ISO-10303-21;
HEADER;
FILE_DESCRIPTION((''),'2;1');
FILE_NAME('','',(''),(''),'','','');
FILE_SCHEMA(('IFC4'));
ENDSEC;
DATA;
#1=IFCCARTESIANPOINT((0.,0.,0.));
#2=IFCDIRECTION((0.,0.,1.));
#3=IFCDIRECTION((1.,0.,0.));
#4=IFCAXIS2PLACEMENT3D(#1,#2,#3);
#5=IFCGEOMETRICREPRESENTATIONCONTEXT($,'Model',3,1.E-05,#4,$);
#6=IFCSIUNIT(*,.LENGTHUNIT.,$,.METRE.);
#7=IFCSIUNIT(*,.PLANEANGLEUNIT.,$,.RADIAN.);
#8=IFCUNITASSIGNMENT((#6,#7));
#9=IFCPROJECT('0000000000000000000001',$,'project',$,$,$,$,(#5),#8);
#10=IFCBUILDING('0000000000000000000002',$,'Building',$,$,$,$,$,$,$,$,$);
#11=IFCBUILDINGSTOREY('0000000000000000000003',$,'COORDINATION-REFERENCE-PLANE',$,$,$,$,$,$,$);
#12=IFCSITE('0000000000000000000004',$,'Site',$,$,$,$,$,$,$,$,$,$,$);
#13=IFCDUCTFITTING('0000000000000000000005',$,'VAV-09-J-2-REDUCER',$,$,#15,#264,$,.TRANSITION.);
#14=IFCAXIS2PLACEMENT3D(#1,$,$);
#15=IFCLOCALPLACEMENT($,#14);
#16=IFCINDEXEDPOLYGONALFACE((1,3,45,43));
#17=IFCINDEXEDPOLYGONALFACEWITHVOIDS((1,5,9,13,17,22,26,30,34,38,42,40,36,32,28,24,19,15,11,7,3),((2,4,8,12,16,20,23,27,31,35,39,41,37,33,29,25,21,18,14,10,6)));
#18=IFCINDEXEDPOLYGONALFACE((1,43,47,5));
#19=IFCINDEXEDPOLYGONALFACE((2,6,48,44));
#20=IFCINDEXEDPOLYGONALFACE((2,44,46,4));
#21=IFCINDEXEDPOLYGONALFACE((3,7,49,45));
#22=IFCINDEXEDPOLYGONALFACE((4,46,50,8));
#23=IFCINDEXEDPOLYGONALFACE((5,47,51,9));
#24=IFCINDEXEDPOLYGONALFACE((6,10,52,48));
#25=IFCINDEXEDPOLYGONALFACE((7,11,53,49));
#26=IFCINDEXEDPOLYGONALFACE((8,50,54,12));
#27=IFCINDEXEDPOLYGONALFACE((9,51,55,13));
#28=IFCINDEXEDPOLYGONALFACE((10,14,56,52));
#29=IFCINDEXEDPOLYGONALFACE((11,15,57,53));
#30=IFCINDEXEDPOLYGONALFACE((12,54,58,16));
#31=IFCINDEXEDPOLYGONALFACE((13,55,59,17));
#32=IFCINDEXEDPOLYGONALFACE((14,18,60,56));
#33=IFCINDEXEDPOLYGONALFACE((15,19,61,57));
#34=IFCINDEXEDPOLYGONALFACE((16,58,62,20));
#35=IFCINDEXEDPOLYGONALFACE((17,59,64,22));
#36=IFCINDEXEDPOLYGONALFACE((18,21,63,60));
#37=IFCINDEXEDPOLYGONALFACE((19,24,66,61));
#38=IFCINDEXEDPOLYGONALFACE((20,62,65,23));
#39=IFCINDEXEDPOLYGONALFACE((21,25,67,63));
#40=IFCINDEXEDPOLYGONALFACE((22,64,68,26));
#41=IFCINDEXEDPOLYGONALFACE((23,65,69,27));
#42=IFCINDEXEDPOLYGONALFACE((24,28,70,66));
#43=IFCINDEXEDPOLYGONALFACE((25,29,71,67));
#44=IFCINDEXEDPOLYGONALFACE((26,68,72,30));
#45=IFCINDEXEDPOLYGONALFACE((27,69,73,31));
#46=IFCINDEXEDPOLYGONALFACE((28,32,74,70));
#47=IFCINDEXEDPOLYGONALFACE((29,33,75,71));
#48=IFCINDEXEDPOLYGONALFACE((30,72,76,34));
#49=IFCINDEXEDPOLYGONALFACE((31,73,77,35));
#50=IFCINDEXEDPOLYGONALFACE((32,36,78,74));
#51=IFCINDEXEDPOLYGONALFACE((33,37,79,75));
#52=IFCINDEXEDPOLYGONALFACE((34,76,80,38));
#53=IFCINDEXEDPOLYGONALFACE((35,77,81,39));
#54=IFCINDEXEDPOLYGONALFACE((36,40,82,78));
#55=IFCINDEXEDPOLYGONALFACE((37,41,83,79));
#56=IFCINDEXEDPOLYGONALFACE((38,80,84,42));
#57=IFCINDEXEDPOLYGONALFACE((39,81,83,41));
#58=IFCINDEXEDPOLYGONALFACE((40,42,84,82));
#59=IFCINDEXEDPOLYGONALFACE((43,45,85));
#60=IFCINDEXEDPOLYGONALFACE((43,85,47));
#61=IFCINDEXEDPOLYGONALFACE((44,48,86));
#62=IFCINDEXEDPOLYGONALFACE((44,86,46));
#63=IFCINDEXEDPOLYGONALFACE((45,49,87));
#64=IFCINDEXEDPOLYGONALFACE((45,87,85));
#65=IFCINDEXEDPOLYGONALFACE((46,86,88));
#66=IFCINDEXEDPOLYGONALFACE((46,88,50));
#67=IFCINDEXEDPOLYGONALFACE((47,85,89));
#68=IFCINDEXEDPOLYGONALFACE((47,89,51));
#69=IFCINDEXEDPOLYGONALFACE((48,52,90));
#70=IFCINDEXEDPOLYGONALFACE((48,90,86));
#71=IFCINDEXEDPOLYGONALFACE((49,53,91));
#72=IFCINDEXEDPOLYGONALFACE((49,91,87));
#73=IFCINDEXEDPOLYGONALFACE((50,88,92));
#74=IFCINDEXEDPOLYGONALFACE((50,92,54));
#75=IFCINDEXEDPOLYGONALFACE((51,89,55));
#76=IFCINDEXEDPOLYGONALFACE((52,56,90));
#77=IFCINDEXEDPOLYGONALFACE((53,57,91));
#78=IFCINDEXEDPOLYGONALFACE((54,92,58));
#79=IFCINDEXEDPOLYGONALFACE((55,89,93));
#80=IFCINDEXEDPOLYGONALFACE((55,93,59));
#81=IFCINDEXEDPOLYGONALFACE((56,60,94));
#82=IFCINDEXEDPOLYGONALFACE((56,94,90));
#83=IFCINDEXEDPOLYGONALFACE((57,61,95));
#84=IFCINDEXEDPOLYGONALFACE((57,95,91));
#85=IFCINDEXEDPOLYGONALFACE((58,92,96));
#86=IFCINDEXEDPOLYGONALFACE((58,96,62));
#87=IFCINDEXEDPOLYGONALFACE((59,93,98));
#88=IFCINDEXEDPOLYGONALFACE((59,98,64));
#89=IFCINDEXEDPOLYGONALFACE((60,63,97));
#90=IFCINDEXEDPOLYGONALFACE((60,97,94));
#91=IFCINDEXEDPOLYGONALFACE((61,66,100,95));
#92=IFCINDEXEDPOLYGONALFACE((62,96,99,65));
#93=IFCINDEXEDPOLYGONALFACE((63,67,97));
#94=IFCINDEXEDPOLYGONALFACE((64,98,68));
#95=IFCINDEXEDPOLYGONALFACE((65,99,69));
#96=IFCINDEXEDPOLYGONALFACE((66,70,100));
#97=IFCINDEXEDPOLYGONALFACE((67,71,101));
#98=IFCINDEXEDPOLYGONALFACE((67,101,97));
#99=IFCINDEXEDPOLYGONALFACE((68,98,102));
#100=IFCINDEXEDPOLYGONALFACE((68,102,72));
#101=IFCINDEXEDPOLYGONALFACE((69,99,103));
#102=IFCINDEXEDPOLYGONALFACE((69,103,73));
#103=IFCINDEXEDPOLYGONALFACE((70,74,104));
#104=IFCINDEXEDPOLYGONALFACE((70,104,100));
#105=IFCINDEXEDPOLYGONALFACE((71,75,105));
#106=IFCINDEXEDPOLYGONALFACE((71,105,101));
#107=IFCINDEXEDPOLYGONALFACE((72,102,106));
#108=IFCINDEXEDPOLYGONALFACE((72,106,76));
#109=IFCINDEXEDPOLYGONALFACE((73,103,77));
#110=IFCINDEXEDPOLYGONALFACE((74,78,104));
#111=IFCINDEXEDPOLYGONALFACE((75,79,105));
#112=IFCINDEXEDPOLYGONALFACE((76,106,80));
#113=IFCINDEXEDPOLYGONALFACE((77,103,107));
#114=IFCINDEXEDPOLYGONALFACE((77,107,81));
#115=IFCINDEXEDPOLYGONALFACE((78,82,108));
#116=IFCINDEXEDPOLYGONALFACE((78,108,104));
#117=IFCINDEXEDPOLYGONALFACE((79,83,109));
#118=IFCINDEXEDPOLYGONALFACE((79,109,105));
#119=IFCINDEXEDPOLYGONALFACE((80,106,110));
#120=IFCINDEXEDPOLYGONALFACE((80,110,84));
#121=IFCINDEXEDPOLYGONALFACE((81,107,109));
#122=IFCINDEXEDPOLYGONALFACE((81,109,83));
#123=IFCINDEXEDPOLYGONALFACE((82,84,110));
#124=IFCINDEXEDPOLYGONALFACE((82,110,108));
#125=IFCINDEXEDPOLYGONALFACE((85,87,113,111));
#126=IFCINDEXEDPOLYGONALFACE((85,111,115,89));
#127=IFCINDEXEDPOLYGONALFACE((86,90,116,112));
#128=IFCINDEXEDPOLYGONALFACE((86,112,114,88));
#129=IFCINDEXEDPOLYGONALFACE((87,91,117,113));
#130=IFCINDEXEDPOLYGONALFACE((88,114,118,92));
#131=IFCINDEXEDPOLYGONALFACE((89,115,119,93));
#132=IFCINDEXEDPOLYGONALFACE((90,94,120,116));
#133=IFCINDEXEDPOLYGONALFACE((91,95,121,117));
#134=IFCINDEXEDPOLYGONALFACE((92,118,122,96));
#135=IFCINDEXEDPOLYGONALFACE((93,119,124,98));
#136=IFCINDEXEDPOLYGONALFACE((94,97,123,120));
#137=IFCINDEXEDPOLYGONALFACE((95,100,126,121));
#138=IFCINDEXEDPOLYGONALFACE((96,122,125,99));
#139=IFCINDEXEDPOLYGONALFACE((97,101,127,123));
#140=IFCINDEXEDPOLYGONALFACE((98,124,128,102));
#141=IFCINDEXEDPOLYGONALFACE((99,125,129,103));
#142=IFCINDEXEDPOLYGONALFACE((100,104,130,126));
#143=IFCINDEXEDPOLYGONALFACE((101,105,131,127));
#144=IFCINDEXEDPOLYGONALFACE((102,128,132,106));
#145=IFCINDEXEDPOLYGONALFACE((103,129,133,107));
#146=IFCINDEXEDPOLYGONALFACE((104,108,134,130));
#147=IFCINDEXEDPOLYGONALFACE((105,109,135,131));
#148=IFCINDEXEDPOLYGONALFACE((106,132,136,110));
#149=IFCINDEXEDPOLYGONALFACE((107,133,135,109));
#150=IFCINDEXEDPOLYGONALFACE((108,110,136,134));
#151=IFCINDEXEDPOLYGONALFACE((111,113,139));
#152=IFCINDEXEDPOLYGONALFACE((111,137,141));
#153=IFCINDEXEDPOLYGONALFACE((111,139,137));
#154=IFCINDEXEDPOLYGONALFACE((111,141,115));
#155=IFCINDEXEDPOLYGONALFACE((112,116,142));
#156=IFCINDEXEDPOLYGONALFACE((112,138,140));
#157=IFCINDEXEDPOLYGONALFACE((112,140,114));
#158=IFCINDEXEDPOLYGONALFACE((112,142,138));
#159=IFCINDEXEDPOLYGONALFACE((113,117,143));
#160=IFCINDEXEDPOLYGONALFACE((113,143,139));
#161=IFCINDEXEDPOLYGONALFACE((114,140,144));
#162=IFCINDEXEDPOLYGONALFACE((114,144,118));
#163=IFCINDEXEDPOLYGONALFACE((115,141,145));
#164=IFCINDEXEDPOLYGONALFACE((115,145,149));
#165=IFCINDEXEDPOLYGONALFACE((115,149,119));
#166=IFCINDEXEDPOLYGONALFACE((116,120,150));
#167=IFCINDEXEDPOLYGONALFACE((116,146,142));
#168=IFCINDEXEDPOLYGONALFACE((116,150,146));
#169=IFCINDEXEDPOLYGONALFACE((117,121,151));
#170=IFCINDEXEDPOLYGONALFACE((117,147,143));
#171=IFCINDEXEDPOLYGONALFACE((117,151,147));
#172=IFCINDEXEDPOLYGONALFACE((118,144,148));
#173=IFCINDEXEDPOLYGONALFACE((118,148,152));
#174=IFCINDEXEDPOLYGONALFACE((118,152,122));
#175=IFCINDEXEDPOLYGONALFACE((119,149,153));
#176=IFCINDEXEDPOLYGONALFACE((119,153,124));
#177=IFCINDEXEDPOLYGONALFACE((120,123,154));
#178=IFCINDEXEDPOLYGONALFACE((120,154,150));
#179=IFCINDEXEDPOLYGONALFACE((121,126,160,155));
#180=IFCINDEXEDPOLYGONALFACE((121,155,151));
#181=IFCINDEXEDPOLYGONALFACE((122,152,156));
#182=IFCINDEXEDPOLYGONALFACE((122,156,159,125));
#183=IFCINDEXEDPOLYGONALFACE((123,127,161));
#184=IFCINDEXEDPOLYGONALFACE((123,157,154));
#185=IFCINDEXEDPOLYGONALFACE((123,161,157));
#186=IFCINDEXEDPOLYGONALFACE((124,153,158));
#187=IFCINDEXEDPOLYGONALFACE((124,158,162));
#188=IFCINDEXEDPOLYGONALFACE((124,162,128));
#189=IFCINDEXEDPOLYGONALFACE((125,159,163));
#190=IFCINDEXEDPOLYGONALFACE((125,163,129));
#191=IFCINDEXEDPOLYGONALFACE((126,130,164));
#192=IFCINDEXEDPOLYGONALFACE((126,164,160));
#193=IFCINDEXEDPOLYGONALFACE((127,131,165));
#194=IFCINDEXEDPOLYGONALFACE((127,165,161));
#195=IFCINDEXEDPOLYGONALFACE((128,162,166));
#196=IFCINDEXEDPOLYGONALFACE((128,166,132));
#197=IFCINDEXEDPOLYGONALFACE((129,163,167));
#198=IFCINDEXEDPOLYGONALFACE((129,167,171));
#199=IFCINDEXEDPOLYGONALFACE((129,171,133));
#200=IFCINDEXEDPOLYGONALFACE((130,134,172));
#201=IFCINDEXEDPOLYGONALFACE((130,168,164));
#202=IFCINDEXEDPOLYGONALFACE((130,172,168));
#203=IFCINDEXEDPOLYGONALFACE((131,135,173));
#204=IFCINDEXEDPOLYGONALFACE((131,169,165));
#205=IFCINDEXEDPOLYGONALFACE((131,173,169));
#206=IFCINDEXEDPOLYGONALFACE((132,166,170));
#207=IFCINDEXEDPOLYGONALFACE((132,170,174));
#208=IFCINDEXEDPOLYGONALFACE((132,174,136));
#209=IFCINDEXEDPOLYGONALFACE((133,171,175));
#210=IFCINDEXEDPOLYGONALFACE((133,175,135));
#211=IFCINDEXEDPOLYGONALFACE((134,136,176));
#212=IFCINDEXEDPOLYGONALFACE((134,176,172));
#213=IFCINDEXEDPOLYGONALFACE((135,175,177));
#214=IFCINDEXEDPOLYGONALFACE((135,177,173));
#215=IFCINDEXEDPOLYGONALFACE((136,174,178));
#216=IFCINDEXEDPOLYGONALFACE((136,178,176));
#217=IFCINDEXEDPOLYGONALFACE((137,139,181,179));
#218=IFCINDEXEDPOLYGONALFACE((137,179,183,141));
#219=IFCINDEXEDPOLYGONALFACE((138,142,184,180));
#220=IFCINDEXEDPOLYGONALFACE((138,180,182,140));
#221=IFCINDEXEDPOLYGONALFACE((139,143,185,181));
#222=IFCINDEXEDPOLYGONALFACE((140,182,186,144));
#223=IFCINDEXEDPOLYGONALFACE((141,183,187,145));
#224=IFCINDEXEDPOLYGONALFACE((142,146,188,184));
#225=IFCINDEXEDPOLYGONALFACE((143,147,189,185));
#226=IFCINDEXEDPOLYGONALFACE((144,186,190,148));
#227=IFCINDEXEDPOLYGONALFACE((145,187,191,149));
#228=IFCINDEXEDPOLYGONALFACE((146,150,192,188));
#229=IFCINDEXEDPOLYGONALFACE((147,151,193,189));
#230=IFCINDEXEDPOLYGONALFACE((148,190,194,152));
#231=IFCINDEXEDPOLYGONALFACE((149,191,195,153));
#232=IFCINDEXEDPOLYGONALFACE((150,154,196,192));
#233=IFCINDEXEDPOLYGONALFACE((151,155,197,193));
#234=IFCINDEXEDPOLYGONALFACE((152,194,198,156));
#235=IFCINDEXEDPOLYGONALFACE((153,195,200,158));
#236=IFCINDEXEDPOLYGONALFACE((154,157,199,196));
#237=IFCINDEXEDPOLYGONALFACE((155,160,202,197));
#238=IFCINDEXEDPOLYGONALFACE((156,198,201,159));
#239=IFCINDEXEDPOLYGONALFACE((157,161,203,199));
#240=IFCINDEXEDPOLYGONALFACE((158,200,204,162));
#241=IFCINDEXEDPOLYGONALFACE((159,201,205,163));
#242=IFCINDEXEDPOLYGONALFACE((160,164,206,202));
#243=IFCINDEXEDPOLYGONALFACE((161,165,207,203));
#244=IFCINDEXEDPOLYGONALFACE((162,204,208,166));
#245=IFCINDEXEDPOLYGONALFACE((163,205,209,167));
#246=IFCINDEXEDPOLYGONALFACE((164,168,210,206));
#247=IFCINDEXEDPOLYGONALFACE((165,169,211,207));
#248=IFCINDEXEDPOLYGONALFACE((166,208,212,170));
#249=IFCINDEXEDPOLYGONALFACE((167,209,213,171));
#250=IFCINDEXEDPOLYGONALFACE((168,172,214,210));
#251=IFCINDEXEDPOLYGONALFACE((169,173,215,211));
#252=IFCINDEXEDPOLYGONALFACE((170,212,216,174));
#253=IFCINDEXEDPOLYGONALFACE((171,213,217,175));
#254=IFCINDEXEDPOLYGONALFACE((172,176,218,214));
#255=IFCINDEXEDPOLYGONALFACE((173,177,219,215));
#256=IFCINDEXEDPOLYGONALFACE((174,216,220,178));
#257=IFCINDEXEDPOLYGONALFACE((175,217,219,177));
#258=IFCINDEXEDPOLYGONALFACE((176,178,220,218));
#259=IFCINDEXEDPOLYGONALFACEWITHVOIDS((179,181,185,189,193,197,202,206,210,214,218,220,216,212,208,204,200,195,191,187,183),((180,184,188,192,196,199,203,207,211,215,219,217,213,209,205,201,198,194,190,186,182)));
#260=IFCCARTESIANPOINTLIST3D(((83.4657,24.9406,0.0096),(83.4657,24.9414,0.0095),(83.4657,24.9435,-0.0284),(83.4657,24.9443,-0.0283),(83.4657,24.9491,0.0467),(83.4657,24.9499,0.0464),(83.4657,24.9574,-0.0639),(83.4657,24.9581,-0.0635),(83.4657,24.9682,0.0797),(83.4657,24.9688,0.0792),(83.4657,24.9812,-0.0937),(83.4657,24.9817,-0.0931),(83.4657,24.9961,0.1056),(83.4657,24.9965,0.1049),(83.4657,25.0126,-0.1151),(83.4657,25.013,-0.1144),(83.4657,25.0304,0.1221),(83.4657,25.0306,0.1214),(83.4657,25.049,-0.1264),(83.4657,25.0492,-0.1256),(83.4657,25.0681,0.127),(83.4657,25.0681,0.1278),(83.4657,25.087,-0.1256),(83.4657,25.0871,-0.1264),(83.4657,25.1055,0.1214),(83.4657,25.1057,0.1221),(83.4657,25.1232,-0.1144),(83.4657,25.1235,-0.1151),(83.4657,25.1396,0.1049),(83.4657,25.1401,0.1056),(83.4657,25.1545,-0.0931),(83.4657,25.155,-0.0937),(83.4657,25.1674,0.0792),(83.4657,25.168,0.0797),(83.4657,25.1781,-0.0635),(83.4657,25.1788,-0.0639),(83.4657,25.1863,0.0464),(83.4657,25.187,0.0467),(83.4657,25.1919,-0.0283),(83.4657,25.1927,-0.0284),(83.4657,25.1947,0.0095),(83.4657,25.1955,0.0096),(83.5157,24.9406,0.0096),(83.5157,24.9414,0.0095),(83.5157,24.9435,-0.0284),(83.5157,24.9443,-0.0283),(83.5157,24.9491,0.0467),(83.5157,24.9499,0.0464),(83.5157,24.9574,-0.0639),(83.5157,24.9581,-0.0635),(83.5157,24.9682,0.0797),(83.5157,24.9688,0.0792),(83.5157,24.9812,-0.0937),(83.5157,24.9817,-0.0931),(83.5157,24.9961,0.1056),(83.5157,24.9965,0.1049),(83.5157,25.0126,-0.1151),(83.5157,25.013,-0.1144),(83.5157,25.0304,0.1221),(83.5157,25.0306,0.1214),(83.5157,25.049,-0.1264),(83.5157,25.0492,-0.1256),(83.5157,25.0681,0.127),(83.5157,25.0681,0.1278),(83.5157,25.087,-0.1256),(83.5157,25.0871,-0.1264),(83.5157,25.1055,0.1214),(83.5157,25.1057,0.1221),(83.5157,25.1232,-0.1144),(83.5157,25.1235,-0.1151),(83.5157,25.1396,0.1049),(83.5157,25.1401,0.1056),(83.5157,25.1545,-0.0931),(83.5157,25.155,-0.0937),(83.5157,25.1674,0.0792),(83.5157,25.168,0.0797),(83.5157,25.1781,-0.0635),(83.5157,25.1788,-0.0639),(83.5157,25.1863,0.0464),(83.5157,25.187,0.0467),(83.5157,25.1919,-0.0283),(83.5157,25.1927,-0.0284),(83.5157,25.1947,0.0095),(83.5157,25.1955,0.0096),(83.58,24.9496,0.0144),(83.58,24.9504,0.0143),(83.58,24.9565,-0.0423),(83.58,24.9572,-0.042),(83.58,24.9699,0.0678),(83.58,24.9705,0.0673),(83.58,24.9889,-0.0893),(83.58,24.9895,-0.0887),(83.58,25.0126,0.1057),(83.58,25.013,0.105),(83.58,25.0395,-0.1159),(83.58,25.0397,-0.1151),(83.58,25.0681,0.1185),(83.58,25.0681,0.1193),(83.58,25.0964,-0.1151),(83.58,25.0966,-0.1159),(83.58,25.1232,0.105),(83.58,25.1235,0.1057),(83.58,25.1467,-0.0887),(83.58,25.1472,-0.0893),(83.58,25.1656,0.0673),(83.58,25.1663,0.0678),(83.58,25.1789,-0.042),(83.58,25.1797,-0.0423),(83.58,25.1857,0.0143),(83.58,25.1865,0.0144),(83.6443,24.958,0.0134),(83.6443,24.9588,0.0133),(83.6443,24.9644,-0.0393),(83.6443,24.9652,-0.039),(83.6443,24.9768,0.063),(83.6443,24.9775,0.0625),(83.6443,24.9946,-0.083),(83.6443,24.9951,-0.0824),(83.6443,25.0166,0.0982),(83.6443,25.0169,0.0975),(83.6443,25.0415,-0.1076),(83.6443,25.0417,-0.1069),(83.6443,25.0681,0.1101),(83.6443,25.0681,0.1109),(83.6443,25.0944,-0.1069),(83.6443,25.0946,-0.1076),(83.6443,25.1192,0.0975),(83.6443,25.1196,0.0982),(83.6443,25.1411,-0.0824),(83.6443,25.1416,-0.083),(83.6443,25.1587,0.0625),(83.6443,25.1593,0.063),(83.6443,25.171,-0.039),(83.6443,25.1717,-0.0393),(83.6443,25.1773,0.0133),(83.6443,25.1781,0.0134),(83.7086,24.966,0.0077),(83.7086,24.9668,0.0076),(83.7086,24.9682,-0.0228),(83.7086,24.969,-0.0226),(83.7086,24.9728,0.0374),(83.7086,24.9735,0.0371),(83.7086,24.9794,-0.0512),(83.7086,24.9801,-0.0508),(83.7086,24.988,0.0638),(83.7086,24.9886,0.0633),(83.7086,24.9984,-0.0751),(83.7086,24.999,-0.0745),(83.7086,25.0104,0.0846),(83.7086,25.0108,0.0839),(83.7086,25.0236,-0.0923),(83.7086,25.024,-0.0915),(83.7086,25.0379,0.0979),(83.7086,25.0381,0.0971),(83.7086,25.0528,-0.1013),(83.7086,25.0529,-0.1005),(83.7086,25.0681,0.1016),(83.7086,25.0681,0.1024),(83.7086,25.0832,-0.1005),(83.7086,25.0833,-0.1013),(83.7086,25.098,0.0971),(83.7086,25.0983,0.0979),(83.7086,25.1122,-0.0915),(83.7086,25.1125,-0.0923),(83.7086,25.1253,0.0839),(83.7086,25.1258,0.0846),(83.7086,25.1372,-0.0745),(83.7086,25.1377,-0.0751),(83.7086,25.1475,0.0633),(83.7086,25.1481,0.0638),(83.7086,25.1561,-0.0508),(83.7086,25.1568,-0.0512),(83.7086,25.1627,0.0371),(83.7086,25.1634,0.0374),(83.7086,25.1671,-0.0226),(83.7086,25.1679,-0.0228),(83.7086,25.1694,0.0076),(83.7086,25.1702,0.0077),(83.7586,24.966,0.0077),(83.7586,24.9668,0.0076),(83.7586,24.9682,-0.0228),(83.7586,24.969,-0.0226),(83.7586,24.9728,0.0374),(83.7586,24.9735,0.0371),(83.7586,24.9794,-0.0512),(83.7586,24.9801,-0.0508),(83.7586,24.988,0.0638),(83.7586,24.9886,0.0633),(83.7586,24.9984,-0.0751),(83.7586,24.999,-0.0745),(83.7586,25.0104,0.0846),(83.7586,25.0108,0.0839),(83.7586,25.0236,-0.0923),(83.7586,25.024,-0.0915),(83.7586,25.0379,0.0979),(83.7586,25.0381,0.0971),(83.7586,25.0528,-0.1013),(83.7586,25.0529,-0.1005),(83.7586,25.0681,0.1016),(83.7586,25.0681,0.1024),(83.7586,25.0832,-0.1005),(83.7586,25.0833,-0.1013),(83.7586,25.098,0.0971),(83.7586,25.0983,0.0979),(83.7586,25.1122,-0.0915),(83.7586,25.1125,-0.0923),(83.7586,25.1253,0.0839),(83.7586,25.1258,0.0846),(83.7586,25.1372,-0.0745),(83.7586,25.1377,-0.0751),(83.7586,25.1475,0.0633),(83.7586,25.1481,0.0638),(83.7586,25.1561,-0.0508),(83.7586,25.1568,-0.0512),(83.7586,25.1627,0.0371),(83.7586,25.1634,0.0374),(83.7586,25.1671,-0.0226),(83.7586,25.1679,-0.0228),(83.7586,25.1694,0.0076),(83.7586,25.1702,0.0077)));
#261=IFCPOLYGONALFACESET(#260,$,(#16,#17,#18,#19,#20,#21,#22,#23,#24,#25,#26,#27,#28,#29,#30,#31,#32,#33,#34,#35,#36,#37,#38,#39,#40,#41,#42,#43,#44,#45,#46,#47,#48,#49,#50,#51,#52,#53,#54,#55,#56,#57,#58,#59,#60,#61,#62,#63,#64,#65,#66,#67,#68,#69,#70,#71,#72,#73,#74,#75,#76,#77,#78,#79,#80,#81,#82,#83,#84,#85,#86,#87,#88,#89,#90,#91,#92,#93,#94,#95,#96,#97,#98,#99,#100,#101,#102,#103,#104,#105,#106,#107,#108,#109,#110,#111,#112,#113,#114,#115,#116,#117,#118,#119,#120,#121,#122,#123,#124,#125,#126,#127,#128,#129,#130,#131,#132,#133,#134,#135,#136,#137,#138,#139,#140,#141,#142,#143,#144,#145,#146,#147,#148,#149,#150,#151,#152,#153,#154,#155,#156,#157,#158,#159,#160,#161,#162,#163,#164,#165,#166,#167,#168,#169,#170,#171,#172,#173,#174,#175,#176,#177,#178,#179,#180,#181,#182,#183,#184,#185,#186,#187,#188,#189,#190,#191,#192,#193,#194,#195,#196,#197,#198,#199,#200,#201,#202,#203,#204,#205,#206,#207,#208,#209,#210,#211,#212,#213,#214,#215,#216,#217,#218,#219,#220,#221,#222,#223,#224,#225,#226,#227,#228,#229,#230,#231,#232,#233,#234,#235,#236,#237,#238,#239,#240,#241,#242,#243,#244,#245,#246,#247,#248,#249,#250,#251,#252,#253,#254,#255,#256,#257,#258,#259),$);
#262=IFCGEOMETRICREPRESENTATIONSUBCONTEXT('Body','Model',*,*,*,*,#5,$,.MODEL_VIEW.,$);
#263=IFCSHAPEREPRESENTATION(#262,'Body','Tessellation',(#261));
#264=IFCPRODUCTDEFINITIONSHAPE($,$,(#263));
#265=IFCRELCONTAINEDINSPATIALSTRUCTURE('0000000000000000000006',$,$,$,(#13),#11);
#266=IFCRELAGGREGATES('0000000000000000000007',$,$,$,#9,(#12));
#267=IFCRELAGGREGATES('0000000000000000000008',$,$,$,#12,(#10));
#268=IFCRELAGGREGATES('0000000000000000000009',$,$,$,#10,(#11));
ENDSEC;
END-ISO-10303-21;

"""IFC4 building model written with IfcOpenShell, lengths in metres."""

from ifc_helpers import new_model, entity, si_unit, frame, origin_with_axes, place, context, subcontext, project, spatial, element, save


model = new_model("IFC4")

# Units and contexts
model_context = context("Model", 3, precision=1e-05, world=origin_with_axes())
body_context_1 = subcontext(model_context, "Body", "Model", "MODEL_VIEW")
ifc_project = project(units=[si_unit("LENGTHUNIT", "METRE"), si_unit("PLANEANGLEUNIT", "RADIAN")], contexts=[model_context])

# Site, building, storey
site = spatial("IfcSite", under=ifc_project, Name="Site")
building = spatial("IfcBuilding", under=site, Name="Building")
storey = spatial("IfcBuildingStorey", under=building, Name="COORDINATION-REFERENCE-PLANE")

# Duct fitting
for number, where, z_axis, x_axis, name in (
    (1, (83.4657, 25.0681, 0.0), (0.0, 1.0, 0.0), (0.0, 0.0, 1.0), "VAV-09-J-2-REDUCER"),
):
    element("IfcDuctFitting", number, at=place(None, frame(where, z_axis=z_axis, x_axis=x_axis)), inside=storey, Name=name, PredefinedType="TRANSITION", context=body_context_1, shape_type="SweptSolid", body=[
        entity("IfcRevolvedAreaSolid", entity("IfcArbitraryClosedProfileDef", "AREA", None, entity("IfcPolyline", [entity("IfcCartesianPoint", [0.1278, 0.0]), entity("IfcCartesianPoint", [0.1278, 0.05]), entity("IfcCartesianPoint", [0.1024, 0.2429]), entity("IfcCartesianPoint", [0.1024, 0.2929]), entity("IfcCartesianPoint", [0.1016, 0.2929]), entity("IfcCartesianPoint", [0.1016, 0.2429]), entity("IfcCartesianPoint", [0.127, 0.05]), entity("IfcCartesianPoint", [0.127, 0.0]), entity("IfcCartesianPoint", [0.1278, 0.0])])), entity("IfcAxis2Placement3D", entity("IfcCartesianPoint", [0.0, 0.0, 0.0])), entity("IfcAxis1Placement", entity("IfcCartesianPoint", [0.0, 0.0, 0.0]), entity("IfcDirection", [0.0, 1.0, 0.0])), 6.283185),
    ])

save(model, "model.ifc")
